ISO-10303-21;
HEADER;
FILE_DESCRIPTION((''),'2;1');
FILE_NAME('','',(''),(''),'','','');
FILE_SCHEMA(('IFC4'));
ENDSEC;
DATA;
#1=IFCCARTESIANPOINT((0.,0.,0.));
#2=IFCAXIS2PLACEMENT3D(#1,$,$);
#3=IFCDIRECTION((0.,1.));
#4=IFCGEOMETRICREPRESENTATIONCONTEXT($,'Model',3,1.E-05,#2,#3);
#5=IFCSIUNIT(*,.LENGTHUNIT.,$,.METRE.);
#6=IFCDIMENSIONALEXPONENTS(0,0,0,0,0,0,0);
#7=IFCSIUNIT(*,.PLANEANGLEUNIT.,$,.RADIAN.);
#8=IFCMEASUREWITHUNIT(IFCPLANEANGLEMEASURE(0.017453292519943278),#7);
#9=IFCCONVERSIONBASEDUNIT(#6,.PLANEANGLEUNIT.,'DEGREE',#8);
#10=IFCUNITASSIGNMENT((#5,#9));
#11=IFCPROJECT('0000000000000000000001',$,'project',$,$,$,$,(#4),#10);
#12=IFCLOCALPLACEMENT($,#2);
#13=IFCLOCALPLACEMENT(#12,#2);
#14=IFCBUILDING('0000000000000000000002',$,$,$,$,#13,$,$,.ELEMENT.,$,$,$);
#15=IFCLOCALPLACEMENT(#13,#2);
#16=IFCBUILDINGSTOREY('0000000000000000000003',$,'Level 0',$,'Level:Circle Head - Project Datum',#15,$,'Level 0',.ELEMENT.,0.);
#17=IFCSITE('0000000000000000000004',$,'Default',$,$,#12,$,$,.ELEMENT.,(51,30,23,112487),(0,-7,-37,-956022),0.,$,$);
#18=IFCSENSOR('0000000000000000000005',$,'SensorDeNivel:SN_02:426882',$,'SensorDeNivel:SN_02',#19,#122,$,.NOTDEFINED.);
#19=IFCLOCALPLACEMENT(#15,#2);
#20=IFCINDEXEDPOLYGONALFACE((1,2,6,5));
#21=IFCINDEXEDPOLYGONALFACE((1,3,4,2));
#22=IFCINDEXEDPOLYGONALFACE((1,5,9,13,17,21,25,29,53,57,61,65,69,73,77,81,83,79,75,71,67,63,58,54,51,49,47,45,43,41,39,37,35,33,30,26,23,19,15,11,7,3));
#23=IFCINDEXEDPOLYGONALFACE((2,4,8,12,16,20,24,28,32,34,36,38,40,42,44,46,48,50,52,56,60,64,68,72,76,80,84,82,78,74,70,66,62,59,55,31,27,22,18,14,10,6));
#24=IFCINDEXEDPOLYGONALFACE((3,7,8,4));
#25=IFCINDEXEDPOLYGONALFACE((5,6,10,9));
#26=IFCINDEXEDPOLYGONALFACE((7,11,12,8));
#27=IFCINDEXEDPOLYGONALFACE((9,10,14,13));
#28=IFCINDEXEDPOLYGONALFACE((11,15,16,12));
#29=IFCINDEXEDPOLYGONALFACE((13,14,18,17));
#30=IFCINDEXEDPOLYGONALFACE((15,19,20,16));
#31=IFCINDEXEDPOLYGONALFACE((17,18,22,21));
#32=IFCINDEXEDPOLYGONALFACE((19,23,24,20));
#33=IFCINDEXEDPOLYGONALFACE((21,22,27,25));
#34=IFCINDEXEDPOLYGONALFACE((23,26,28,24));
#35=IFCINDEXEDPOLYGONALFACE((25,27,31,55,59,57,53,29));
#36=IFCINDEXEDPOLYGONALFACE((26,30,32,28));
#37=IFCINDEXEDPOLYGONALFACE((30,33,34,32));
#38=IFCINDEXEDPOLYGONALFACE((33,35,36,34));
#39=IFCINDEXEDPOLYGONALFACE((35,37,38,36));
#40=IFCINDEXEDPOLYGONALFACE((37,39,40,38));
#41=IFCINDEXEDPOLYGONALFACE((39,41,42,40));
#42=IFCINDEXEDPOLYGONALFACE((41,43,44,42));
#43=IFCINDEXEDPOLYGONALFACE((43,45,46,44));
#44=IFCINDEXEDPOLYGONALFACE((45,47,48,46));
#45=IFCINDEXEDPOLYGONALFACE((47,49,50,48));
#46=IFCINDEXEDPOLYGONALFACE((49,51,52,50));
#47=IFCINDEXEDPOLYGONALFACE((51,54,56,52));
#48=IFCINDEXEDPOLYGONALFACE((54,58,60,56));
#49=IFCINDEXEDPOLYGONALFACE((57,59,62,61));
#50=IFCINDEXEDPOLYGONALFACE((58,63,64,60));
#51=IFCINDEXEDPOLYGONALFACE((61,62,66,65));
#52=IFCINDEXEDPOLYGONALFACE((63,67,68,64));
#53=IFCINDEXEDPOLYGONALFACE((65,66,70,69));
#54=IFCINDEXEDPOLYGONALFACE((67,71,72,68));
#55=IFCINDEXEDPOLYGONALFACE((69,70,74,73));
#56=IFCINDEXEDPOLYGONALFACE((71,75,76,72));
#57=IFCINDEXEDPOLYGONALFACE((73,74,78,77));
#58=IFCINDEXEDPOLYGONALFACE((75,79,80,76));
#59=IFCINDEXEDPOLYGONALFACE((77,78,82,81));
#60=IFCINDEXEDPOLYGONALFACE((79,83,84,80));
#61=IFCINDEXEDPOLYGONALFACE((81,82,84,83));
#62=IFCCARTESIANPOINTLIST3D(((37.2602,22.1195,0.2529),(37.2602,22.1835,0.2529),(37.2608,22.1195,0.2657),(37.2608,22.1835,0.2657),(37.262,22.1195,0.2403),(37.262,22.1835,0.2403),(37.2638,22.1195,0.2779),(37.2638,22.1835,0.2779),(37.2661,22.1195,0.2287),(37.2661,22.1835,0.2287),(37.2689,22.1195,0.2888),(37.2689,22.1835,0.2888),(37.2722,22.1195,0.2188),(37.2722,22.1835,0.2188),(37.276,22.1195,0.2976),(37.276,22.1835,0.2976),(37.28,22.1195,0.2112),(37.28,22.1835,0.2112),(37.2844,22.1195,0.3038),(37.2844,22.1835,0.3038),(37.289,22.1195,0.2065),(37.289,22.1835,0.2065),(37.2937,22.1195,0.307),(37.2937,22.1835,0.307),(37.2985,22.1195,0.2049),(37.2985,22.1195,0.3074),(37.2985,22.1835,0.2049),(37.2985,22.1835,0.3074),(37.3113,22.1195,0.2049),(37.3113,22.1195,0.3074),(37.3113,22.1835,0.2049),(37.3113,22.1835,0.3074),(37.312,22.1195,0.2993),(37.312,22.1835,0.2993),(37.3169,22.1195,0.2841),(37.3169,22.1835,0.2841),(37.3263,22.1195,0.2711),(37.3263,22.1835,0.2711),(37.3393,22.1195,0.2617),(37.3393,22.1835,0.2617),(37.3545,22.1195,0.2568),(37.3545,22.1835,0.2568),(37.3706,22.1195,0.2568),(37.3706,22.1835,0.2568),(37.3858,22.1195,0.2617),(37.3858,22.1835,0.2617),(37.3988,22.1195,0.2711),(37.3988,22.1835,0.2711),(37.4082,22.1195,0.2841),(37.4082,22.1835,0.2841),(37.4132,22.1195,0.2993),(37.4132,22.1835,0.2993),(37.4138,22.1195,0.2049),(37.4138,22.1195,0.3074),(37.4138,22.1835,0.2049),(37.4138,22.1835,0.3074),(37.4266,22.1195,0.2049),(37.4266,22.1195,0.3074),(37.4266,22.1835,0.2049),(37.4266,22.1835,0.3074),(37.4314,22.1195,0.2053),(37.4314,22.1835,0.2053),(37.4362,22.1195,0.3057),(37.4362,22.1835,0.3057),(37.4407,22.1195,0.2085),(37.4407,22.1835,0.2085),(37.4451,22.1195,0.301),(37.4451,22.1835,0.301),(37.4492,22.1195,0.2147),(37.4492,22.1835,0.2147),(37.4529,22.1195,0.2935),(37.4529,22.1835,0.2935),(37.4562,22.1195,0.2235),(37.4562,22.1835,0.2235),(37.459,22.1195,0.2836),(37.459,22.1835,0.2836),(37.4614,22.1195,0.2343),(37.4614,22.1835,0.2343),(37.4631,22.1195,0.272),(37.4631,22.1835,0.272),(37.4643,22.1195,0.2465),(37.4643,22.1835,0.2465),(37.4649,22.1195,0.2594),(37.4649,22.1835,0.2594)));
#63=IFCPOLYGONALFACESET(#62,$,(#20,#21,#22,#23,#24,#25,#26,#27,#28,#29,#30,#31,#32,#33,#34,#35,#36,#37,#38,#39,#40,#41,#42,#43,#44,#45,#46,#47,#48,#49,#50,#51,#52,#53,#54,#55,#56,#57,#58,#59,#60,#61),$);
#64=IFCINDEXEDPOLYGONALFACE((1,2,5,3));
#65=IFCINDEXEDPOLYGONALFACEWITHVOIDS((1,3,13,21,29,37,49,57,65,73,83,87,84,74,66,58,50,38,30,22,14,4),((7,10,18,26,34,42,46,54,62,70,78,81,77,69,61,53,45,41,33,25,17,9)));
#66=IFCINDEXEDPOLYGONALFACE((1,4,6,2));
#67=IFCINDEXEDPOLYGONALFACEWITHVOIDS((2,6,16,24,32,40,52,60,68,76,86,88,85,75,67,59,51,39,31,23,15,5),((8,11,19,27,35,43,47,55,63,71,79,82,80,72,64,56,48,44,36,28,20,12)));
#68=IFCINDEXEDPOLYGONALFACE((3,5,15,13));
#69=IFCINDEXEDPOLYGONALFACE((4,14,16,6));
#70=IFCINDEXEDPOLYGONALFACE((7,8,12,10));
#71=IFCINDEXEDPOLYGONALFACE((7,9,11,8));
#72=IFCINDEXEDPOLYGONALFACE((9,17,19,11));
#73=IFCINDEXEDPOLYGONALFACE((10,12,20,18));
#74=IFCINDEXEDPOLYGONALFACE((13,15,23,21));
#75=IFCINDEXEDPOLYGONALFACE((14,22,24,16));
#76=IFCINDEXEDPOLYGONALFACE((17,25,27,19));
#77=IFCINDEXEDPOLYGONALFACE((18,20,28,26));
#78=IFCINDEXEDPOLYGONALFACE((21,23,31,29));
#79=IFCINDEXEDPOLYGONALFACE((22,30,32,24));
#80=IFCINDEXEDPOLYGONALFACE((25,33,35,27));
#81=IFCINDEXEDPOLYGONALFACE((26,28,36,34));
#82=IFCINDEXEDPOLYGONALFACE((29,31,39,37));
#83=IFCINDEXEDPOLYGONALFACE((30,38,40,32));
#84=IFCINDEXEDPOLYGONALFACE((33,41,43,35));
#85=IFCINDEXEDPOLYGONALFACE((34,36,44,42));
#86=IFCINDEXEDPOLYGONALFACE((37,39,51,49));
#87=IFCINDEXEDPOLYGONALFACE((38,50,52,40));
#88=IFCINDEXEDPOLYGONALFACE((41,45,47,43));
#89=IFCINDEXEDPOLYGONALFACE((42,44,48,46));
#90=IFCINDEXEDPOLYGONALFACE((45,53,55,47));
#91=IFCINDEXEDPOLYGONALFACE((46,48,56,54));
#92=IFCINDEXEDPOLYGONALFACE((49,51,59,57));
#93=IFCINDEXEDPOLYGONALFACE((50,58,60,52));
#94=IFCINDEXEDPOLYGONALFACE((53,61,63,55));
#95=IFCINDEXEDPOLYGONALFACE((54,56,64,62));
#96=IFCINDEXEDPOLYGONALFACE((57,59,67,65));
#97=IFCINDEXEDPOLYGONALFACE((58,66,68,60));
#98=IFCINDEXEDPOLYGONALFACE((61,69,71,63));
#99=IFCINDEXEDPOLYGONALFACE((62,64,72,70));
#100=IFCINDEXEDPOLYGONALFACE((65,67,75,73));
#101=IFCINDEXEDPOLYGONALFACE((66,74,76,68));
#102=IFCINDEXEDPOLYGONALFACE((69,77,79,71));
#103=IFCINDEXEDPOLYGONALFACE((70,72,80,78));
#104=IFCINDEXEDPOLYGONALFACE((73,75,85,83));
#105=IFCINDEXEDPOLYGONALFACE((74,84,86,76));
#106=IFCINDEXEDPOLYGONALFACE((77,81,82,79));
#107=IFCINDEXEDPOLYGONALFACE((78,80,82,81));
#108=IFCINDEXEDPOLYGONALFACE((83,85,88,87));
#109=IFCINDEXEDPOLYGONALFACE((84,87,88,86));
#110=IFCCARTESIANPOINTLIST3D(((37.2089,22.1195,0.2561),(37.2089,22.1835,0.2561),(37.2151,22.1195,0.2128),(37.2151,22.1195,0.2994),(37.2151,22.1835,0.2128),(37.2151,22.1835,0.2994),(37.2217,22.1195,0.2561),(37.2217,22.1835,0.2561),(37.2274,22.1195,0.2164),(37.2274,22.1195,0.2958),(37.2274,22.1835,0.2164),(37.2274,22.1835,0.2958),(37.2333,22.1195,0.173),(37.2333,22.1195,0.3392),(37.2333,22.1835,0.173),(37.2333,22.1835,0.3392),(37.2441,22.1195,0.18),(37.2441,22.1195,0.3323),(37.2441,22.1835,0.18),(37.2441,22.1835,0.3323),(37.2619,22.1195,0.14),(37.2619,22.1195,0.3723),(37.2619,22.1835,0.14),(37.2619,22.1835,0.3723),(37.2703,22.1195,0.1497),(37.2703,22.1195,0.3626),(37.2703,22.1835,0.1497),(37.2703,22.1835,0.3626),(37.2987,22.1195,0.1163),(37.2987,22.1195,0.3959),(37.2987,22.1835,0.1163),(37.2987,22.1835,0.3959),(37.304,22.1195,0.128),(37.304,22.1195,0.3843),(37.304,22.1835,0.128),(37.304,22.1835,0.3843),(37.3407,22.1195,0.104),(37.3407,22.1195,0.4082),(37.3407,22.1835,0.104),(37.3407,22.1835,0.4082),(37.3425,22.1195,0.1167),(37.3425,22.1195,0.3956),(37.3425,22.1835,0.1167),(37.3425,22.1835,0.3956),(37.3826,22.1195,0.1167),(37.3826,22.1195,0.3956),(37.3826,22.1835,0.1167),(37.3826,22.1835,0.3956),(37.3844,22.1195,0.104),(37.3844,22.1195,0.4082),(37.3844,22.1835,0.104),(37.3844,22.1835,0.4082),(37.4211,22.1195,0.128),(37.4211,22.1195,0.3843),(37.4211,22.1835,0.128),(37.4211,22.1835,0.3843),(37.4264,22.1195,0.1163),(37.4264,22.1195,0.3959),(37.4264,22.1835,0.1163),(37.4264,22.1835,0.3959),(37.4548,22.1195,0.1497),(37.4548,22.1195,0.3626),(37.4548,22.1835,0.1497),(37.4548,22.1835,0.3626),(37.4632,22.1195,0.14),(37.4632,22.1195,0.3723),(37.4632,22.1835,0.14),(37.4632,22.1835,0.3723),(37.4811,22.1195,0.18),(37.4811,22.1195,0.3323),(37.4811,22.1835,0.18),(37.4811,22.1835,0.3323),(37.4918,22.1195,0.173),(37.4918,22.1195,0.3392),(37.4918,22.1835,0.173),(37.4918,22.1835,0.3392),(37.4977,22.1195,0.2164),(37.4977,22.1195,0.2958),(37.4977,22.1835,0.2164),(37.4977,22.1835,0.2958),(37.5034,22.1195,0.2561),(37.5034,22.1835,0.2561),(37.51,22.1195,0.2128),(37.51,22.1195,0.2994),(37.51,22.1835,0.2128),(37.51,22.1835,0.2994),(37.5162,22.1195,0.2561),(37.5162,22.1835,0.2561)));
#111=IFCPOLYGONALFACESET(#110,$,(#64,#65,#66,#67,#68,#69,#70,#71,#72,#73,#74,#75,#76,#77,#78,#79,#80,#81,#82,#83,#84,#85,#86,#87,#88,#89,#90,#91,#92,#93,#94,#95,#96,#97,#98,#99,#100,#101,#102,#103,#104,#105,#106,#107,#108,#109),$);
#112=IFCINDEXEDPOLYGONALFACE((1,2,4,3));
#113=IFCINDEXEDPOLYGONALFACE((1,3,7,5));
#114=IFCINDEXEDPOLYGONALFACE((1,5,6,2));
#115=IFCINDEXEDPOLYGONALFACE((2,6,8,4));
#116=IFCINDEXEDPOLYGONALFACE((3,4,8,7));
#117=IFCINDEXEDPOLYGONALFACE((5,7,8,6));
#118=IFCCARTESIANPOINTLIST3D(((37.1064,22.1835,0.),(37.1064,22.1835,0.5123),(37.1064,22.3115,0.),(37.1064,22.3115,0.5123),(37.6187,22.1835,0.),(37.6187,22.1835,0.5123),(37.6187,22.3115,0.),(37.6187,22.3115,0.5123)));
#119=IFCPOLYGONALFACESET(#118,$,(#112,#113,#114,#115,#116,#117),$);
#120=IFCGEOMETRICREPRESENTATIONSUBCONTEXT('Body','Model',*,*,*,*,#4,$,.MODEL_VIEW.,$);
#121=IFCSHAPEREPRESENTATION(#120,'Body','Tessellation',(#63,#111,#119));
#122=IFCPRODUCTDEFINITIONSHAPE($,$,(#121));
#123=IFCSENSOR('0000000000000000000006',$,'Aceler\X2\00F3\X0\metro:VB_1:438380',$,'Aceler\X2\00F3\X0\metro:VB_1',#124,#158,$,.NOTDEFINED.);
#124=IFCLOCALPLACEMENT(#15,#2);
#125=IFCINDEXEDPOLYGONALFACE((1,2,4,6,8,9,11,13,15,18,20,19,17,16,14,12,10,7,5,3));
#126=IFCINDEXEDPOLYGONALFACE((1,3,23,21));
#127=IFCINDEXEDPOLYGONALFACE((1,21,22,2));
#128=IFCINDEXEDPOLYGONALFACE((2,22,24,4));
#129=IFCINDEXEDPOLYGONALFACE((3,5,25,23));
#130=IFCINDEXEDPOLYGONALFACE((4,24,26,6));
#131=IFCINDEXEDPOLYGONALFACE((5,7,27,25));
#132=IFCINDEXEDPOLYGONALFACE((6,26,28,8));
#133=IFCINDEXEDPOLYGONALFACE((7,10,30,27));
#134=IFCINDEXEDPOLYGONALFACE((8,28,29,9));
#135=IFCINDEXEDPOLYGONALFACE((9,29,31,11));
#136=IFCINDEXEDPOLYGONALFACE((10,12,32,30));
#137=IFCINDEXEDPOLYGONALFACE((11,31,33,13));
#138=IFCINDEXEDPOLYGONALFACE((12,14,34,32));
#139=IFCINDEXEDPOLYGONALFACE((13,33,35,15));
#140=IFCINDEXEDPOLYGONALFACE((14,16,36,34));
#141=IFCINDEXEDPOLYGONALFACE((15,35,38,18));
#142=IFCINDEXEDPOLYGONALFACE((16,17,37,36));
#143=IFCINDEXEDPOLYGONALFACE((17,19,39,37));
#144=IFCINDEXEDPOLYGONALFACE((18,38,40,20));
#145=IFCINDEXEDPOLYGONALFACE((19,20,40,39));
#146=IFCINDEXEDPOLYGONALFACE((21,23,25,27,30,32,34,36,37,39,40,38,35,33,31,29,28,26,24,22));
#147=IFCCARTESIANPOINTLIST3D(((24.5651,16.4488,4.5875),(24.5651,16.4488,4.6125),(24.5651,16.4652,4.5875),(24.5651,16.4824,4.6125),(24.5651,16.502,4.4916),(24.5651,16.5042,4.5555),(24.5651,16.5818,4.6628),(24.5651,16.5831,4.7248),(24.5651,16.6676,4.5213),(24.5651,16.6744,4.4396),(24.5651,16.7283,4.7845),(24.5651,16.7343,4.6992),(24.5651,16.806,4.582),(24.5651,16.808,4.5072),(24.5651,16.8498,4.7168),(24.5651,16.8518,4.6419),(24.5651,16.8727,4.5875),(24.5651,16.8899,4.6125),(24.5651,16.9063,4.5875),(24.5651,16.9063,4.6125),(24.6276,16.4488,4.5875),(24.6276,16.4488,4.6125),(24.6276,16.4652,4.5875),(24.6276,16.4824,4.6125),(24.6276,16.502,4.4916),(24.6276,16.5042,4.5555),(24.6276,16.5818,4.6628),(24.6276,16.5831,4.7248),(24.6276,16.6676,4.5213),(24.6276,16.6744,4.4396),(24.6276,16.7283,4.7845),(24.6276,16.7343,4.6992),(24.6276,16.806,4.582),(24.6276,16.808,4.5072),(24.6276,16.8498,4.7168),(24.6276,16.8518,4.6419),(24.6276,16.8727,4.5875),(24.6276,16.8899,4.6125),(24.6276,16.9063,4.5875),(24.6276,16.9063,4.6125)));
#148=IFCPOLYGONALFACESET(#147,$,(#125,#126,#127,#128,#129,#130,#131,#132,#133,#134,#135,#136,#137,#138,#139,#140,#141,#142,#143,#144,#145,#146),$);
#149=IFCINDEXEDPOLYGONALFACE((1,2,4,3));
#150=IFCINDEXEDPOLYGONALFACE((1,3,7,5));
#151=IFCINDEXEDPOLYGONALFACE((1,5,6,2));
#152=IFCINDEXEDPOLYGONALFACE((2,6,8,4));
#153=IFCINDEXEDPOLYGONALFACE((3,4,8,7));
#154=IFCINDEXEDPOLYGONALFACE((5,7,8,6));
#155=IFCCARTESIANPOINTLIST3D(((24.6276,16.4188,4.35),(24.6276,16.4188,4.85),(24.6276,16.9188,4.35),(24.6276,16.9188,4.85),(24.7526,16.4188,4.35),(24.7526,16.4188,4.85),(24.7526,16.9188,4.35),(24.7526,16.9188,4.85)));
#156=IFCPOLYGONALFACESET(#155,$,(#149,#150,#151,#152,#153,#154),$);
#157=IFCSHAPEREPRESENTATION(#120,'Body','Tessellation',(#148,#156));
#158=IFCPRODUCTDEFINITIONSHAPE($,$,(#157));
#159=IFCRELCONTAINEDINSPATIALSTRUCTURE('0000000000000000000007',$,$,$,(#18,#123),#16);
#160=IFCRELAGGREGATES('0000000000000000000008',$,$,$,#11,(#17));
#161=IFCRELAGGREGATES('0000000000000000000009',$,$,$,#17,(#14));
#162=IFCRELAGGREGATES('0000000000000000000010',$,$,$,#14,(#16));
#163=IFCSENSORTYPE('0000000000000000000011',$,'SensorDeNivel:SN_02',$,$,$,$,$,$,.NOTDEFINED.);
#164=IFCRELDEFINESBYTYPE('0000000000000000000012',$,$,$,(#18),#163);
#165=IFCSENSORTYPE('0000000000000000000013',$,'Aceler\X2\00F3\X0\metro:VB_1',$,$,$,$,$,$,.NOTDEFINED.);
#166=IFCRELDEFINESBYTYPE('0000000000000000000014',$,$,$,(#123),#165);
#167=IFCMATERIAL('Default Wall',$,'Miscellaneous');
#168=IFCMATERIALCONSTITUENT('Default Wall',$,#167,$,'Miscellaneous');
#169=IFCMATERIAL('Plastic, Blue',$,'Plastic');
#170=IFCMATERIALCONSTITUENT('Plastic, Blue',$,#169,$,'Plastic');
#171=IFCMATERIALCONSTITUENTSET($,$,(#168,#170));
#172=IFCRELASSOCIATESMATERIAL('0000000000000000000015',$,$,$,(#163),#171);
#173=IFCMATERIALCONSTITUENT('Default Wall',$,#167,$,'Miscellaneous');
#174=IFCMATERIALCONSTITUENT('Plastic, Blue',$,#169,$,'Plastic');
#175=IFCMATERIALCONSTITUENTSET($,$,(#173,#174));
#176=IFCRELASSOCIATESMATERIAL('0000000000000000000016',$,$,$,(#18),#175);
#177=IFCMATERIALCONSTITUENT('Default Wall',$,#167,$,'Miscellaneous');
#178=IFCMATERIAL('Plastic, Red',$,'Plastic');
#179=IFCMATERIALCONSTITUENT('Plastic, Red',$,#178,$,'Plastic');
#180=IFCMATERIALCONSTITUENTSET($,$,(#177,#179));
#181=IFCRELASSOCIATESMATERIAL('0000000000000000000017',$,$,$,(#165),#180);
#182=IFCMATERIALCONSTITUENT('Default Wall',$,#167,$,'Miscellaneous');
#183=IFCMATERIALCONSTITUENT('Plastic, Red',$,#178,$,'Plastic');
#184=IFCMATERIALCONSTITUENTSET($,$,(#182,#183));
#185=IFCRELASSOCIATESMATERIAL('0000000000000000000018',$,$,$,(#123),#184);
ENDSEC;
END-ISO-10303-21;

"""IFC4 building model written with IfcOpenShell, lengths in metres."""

from ifc_helpers import new_model, entity, si_unit, converted_unit, direction, frame, origin, place, context, subcontext, project, spatial, arc, indexed_curve, outline, extrude, source, transform, mapped, material, constituent, constituent_set, type_object, type_shapes, element, save


model = new_model("IFC4")

# Units and contexts
model_context = context("Model", 3, precision=1e-05, world=origin(), true_north=direction((0.0, 1.0)))
body_context = subcontext(model_context, "Body", "Model", "MODEL_VIEW")
ifc_project = project(units=[si_unit("LENGTHUNIT", "METRE"), converted_unit("PLANEANGLEUNIT", "DEGREE", entity("IfcPlaneAngleMeasure", 0.017453292519943278), si_unit("PLANEANGLEUNIT", "RADIAN"), dimensions=[0, 0, 0, 0, 0, 0, 0])], contexts=[model_context])

# Site, building, storey
site_placement = place(None, origin())
site = spatial("IfcSite", under=ifc_project, at=site_placement, Name="Default", CompositionType="ELEMENT", RefLatitude=(51, 30, 23, 112487), RefLongitude=(0, -7, -37, -956022), RefElevation=0.0)
building_placement = place(site_placement, origin())
building = spatial("IfcBuilding", under=site, at=building_placement, CompositionType="ELEMENT")
storey_placement = place(building_placement, origin())
storey = spatial("IfcBuildingStorey", under=building, at=storey_placement, Name="Level 0", ObjectType="Level:Circle Head - Project Datum", LongName="Level 0", CompositionType="ELEMENT", Elevation=0.0)

# Sensors
ifc_material_1 = material(Name="Default Wall", Category="Miscellaneous")
ifc_material_2 = material(Name="Plastic, Blue", Category="Plastic")
ifc_constituent_1 = constituent(ifc_material_1, Name="Default Wall", Category="Miscellaneous")
ifc_constituent_2 = constituent(ifc_material_2, Name="Plastic, Blue", Category="Plastic")
ifc_constituent_set_1 = constituent_set(constituents=[ifc_constituent_1, ifc_constituent_2])
ifc_constituent_3 = constituent(ifc_material_1, Name="Default Wall", Category="Miscellaneous")
ifc_constituent_4 = constituent(ifc_material_2, Name="Plastic, Blue", Category="Plastic")
ifc_constituent_set_2 = constituent_set(constituents=[ifc_constituent_3, ifc_constituent_4])
sensor_type_1 = type_object("IfcSensorType", Name="SensorDeNivel:SN_02", PredefinedType="NOTDEFINED", material=ifc_constituent_set_2)
shared_shape_1 = source(origin(), body_context, "Body", "SweptSolid", [
    extrude(outline(indexed_curve([(0.0512, -0.0556), (0.064, -0.0556), (0.0736, -0.054), (0.0825, -0.0493), (0.0903, -0.0417), (0.0965, -0.0318), (0.1006, -0.0202), (0.1024, -0.0076), (0.1018, 0.0052), (0.0988, 0.0174), (0.0936, 0.0283), (0.0866, 0.037), (0.0782, 0.0432), (0.0689, 0.0464), (0.064, 0.0468), (0.0512, 0.0468), (0.0506, 0.0388), (0.0456, 0.0236), (0.0362, 0.0106), (0.0233, 0.0012), (0.008, -0.0038), (-0.008, -0.0038), (-0.0233, 0.0012), (-0.0362, 0.0106), (-0.0456, 0.0236), (-0.0506, 0.0388), (-0.0512, 0.0468), (-0.064, 0.0468), (-0.0736, 0.0452), (-0.0825, 0.0405), (-0.0903, 0.0329), (-0.0965, 0.023), (-0.1006, 0.0114), (-0.1024, -0.0012), (-0.1018, -0.014), (-0.0988, -0.0262), (-0.0936, -0.0371), (-0.0866, -0.0458), (-0.0782, -0.052), (-0.0689, -0.0552), (-0.064, -0.0556), (-0.0512, -0.0556), (0.0512, -0.0556)], self_intersect=False)), frame((0.0, -0.1281, 0.2605), z_axis=(0.0, 1.0, 0.0), x_axis=(-1.0, 0.0, 0.0)), (0.0, 0.0, 1.0), 0.064),
    extrude(outline(indexed_curve([(-0.1537, 0.0), (0.0, -0.1537), (0.1537, 0.0), (0.0, 0.1537)], segments=[arc(1, 2, 3), arc(3, 4, 1)], self_intersect=False), holes=[indexed_curve([(-0.1409, 0.0), (0.0, 0.1409), (0.1409, 0.0), (0.0, -0.1409)], segments=[arc(1, 2, 3), arc(3, 4, 1)], self_intersect=False)]), frame((0.0, -0.1281, 0.2561), z_axis=(0.0, 1.0, 0.0), x_axis=(1.0, 0.0, 0.0)), (0.0, 0.0, 1.0), 0.064),
    extrude(outline(indexed_curve([(-0.2561, -0.064), (0.2561, -0.064), (0.2561, 0.064), (-0.2561, 0.064), (-0.2561, -0.064)], self_intersect=False)), frame((0.0, 0.0, 0.0), z_axis=(0.0, 0.0, 1.0), x_axis=(-1.0, 0.0, 0.0)), (0.0, 0.0, 1.0), 0.5123),
])
type_shapes(sensor_type_1, [shared_shape_1])
sensor_1_placement = place(storey_placement, frame((37.3626, 22.2475, 0.0)))
element("IfcSensor", 1, at=sensor_1_placement, inside=storey, type_object=sensor_type_1, material=ifc_constituent_set_1, Name="SensorDeNivel:SN_02:426882", ObjectType="SensorDeNivel:SN_02", PredefinedType="NOTDEFINED", context=body_context, shape_type="MappedRepresentation", body=[
    mapped(shared_shape_1, transform((0.0, 0.0, 0.0), scale=1.0)),
])
ifc_constituent_5 = constituent(ifc_material_1, Name="Default Wall", Category="Miscellaneous")
ifc_material_3 = material(Name="Plastic, Red", Category="Plastic")
ifc_constituent_6 = constituent(ifc_material_3, Name="Plastic, Red", Category="Plastic")
ifc_constituent_set_3 = constituent_set(constituents=[ifc_constituent_5, ifc_constituent_6])
ifc_constituent_7 = constituent(ifc_material_1, Name="Default Wall", Category="Miscellaneous")
ifc_constituent_8 = constituent(ifc_material_3, Name="Plastic, Red", Category="Plastic")
ifc_constituent_set_4 = constituent_set(constituents=[ifc_constituent_7, ifc_constituent_8])
sensor_type_2 = type_object("IfcSensorType", Name="Acelerómetro:VB_1", PredefinedType="NOTDEFINED", material=ifc_constituent_set_4)
shared_shape_2 = source(origin(), body_context, "Body", "SweptSolid", [
    extrude(outline(indexed_curve([(-0.0675, -0.1929), (0.0442, -0.1929), (-0.0659, -0.1038), (0.1509, -0.1038), (-0.073, 0.0473), (0.1473, 0.0532), (0.0176, 0.1875), (0.0786, 0.1875), (0.0906, 0.2189), (0.0673, 0.2278), (0.0614, 0.2125), (-0.0413, 0.2125), (0.0899, 0.0767), (-0.1517, 0.0702), (0.0692, -0.0788), (-0.1365, -0.0788), (-0.0264, -0.1679), (-0.0847, -0.1679), (-0.0967, -0.1993), (-0.0734, -0.2082), (-0.0675, -0.1929)], self_intersect=False)), frame((-0.0168, -0.125, 0.2564), z_axis=(0.0, 1.0, 0.0), x_axis=(0.358368, 0.0, 0.93358)), (0.0, 0.0, 1.0), 0.0625),
    extrude(outline(indexed_curve([(-0.25, -0.0625), (0.25, -0.0625), (0.25, 0.0625), (-0.25, 0.0625), (-0.25, -0.0625)], self_intersect=False)), frame((0.0, 0.0, 0.0), z_axis=(0.0, 0.0, 1.0), x_axis=(-1.0, 0.0, 0.0)), (0.0, 0.0, 1.0), 0.5),
])
type_shapes(sensor_type_2, [shared_shape_2])
sensor_2_placement = place(storey_placement, frame((24.6901, 16.6688, 4.35), z_axis=(0.0, 0.0, 1.0), x_axis=(0.0, -1.0, 0.0)))
element("IfcSensor", 2, at=sensor_2_placement, inside=storey, type_object=sensor_type_2, material=ifc_constituent_set_3, Name="Acelerómetro:VB_1:438380", ObjectType="Acelerómetro:VB_1", PredefinedType="NOTDEFINED", context=body_context, shape_type="MappedRepresentation", body=[
    mapped(shared_shape_2, transform((0.0, 0.0, 0.0), scale=1.0)),
])

save(model, "model.ifc")
